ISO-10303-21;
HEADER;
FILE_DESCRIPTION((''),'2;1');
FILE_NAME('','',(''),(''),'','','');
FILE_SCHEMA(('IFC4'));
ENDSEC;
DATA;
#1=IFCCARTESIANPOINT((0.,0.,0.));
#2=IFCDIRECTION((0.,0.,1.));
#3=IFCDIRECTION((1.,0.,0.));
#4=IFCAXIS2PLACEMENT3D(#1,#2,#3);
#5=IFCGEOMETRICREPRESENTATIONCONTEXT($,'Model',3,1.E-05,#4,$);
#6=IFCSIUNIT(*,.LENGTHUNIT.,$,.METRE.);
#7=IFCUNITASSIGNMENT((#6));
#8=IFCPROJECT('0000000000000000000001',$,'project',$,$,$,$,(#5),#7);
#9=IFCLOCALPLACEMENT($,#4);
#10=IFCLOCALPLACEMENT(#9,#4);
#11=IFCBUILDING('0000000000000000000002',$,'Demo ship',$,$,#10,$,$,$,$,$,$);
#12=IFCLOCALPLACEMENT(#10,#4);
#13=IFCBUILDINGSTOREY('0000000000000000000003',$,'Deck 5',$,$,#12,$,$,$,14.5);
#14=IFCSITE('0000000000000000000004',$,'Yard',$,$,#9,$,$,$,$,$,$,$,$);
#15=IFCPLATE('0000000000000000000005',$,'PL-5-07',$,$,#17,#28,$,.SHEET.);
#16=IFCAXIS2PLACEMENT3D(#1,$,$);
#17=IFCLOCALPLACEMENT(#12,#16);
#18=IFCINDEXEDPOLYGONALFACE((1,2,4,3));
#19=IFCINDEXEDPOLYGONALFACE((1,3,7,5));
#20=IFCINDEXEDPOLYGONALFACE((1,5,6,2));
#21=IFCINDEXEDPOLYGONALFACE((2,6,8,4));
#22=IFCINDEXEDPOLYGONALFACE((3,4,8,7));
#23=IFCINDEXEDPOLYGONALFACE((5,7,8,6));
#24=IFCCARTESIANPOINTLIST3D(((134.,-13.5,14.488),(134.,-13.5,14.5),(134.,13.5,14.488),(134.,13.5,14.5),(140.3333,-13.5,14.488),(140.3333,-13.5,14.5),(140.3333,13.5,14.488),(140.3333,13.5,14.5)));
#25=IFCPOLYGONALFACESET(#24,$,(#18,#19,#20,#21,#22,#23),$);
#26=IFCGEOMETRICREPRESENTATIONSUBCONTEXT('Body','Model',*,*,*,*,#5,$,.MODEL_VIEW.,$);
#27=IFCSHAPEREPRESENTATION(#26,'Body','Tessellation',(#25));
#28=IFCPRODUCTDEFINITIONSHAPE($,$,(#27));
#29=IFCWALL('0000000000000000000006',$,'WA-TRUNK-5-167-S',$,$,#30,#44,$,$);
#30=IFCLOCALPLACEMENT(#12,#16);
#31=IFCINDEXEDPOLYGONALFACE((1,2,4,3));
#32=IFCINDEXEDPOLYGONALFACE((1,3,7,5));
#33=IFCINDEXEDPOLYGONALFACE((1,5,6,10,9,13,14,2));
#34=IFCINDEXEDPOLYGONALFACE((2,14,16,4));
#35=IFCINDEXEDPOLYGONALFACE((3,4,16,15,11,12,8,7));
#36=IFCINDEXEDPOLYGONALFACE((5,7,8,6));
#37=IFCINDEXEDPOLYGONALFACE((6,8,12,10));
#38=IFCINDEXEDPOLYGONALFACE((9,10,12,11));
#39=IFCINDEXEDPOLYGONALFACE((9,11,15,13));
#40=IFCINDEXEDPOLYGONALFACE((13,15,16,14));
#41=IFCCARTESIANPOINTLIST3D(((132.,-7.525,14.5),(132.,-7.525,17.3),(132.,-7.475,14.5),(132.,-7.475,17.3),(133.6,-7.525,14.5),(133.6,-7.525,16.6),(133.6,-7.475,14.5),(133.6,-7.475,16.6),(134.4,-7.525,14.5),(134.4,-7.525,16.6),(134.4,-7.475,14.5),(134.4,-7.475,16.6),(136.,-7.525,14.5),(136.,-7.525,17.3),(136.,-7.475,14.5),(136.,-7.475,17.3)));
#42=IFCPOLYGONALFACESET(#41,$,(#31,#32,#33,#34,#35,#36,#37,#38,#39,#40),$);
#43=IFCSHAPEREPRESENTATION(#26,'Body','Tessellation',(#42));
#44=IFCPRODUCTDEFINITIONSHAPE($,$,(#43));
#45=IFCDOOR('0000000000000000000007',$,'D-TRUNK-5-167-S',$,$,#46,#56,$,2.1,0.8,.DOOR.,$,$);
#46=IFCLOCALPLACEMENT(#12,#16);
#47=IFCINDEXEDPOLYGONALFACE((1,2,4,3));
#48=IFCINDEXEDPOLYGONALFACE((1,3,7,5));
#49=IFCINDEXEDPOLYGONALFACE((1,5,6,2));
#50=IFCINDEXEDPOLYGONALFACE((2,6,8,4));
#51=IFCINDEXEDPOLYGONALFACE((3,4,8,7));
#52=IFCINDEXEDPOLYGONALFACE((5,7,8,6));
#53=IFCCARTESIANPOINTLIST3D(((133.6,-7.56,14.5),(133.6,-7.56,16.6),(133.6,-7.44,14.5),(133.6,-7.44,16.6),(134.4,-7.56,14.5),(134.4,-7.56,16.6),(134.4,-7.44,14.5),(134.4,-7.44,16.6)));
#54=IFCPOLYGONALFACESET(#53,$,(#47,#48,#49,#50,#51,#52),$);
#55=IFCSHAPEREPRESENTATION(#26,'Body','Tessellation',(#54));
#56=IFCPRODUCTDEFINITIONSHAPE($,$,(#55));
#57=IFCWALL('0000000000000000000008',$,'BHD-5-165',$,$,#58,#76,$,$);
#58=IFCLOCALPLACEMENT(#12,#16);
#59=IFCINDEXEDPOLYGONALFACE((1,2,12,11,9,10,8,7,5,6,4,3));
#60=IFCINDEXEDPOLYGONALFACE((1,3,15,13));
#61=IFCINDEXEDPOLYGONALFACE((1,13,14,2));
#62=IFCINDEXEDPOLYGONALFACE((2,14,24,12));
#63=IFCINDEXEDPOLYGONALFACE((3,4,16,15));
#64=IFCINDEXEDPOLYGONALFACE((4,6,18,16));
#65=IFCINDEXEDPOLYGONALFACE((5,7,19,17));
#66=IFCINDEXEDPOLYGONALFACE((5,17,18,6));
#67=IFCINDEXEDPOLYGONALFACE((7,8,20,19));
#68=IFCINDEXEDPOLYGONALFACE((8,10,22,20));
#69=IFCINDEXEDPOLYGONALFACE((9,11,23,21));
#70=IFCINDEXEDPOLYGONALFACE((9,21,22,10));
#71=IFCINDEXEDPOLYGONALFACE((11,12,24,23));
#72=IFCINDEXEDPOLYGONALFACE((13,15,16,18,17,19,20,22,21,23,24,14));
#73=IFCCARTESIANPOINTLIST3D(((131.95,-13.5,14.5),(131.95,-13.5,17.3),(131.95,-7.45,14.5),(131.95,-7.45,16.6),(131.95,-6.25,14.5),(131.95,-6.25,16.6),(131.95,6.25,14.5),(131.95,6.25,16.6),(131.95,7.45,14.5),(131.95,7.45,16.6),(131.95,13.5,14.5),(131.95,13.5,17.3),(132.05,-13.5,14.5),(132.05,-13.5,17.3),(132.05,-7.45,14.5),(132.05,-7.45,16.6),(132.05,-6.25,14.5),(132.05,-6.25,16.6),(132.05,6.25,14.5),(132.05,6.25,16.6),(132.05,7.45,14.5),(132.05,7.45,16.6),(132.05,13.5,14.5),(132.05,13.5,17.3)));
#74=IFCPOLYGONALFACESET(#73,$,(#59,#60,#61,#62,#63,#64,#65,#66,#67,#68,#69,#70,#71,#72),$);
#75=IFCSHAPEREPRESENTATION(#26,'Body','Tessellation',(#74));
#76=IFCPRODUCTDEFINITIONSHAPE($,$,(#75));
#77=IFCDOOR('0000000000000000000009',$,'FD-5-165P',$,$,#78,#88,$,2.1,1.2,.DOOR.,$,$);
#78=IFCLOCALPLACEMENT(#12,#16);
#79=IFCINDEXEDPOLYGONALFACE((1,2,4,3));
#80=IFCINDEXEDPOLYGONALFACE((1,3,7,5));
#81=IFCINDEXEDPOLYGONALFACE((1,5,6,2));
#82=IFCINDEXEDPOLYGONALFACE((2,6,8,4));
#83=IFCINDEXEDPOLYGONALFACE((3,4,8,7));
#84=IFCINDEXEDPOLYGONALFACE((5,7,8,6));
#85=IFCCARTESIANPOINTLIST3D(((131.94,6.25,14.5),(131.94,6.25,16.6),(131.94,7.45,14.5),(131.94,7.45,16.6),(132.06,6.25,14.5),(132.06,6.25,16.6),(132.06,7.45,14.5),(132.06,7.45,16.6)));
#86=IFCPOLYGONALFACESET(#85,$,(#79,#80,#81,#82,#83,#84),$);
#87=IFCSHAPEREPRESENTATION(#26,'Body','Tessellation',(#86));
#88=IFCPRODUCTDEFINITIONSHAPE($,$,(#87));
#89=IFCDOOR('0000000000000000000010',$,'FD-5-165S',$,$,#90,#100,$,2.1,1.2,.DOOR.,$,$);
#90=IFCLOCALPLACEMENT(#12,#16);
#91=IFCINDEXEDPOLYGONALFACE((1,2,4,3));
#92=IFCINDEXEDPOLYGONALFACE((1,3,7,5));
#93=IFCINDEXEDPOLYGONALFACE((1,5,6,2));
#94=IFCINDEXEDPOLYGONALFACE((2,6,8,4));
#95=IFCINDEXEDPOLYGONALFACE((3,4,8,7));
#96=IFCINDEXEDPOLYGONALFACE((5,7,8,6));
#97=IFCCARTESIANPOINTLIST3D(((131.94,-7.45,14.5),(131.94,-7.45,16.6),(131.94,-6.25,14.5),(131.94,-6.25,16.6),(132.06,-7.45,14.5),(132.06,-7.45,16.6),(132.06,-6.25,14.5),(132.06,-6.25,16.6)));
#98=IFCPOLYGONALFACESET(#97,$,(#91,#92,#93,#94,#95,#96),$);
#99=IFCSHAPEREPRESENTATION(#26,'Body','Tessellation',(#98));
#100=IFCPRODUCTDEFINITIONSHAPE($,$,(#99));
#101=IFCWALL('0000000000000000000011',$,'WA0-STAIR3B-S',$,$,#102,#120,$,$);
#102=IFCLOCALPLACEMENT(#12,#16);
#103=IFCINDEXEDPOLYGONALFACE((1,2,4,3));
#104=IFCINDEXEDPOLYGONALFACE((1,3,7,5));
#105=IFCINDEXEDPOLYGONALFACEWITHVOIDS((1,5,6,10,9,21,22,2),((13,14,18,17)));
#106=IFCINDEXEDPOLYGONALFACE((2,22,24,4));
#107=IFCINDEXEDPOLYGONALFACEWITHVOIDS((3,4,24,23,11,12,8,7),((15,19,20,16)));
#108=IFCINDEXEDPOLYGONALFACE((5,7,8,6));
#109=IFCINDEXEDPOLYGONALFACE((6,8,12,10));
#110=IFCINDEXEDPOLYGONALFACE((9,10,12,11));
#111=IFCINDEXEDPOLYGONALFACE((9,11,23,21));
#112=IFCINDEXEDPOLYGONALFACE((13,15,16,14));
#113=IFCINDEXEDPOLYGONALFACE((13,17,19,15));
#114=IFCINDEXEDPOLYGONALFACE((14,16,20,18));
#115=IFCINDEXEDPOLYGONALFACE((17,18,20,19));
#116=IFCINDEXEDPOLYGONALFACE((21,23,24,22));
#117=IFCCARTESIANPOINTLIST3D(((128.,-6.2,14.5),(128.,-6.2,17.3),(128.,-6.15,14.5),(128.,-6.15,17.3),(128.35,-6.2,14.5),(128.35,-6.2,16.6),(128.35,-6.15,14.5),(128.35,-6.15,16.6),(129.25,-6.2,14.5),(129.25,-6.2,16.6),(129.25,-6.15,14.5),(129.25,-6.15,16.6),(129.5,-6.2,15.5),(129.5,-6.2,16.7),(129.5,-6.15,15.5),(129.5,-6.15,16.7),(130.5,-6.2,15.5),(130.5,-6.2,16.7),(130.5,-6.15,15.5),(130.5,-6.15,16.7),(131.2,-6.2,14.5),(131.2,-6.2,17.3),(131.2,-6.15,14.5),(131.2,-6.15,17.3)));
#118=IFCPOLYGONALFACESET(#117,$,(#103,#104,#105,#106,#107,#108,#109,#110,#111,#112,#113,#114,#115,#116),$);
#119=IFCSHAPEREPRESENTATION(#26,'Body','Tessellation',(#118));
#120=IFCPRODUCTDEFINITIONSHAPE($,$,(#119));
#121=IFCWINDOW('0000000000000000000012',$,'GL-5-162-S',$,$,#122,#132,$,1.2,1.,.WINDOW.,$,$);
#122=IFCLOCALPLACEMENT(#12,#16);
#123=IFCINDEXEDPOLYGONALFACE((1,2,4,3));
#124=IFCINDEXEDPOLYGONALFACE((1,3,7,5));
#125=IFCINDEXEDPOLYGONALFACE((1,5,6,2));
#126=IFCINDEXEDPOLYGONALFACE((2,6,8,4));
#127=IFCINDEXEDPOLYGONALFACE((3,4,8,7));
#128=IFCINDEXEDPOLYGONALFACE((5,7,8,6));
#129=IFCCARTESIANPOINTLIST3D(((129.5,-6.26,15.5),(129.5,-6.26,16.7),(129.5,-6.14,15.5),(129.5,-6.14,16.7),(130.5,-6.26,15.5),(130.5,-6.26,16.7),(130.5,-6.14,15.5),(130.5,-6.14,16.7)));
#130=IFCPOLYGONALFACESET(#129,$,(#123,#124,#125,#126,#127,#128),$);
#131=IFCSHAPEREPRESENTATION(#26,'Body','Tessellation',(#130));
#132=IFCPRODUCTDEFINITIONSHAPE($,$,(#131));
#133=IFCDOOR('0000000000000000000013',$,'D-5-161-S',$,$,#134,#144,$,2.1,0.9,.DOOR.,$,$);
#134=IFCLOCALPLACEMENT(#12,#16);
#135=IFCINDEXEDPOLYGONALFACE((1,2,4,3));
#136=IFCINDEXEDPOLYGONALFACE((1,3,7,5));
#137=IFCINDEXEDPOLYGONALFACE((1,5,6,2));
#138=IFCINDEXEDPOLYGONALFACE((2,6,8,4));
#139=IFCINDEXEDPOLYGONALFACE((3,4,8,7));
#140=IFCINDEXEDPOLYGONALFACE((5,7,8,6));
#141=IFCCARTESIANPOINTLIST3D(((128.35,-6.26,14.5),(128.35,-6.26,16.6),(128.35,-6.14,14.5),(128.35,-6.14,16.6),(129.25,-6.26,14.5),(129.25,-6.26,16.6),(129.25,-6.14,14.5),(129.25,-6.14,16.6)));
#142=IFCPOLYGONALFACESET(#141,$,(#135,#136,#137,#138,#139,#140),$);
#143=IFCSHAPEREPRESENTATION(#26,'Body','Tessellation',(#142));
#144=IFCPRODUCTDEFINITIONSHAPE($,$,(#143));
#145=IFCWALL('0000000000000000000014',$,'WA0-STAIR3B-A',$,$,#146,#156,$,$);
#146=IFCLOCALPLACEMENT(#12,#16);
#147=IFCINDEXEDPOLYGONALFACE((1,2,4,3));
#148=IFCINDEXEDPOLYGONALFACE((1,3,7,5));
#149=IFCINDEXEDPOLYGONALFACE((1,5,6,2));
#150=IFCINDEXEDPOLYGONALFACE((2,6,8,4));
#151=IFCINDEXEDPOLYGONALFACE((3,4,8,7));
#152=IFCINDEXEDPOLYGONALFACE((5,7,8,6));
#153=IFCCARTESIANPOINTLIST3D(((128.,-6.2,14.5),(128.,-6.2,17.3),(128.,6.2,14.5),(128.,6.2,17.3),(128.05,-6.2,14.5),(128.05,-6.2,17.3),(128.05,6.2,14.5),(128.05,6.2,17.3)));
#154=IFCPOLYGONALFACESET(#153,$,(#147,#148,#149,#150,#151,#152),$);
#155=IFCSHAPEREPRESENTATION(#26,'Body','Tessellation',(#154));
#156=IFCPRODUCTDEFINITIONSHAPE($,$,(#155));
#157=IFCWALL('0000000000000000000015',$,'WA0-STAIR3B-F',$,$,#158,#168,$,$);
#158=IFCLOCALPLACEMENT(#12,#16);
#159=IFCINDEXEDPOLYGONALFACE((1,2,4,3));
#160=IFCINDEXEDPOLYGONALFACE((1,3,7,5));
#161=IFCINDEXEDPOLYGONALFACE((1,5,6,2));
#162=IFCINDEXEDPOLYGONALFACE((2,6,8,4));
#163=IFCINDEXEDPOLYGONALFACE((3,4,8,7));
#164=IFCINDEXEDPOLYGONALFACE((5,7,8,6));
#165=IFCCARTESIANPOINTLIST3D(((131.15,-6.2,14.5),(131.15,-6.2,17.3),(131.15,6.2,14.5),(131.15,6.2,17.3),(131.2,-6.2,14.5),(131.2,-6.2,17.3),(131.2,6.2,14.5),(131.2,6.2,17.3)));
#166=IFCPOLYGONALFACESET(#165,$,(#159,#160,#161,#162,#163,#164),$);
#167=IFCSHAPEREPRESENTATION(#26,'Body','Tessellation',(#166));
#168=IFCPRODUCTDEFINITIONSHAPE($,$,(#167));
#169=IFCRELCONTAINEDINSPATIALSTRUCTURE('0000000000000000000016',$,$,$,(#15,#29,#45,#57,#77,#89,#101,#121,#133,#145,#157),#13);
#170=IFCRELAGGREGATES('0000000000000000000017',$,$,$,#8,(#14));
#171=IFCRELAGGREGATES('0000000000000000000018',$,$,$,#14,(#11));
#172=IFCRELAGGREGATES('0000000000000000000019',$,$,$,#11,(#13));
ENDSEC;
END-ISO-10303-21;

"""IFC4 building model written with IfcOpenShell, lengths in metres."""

from ifc_helpers import new_model, si_unit, frame, frame_2d, origin, origin_with_axes, place, context, subcontext, project, spatial, rectangle, extrude, element, fill, save


model = new_model("IFC4")

# Units and contexts
model_context = context("Model", 3, precision=1e-05, world=origin_with_axes())
body_context = subcontext(model_context, "Body", "Model", "MODEL_VIEW")
ifc_project = project(units=[si_unit("LENGTHUNIT", "METRE")], contexts=[model_context])

# Site, building, storey
site_placement = place(None, origin_with_axes())
site = spatial("IfcSite", under=ifc_project, at=site_placement, Name="Yard")
building_placement = place(site_placement, origin_with_axes())
building = spatial("IfcBuilding", under=site, at=building_placement, Name="Demo ship")
storey_placement = place(building_placement, origin_with_axes())
storey = spatial("IfcBuildingStorey", under=building, at=storey_placement, Name="Deck 5", Elevation=14.5)

# Plate
plate_placement = place(storey_placement, frame((134.0, -13.5, 14.488), z_axis=(0.0, 0.0, 1.0), x_axis=(1.0, 0.0, 0.0)))
element("IfcPlate", 1, at=plate_placement, inside=storey, Name="PL-5-07", PredefinedType="SHEET", context=body_context, shape_type="SweptSolid", body=[
    extrude(rectangle(XDim=6.3333, YDim=27.0, at=frame_2d((3.1667, 13.5))), origin(), (0.0, 0.0, 1.0), 0.012),
])

# Wall, opening, door
wall_1_placement = place(storey_placement, frame((132.0, -7.525, 14.5), z_axis=(0.0, 0.0, 1.0), x_axis=(1.0, 0.0, 0.0)))
wall_1 = element("IfcWall", 2, at=wall_1_placement, inside=storey, Name="WA-TRUNK-5-167-S", context=body_context, shape_type="SweptSolid", body=[
    extrude(rectangle(XDim=4.0, YDim=0.05, at=frame_2d((2.0, 0.025))), origin(), (0.0, 0.0, 1.0), 2.8),
])
opening_1_placement = place(None, frame((133.6, -7.56, 14.5), z_axis=(0.0, 0.0, 1.0), x_axis=(1.0, 0.0, 0.0)))
opening_1 = element("IfcOpeningElement", 3, at=opening_1_placement, cuts=wall_1, context=body_context, shape_type="SweptSolid", body=[
    extrude(rectangle(XDim=0.8, YDim=0.12, at=frame_2d((0.4, 0.06))), origin(), (0.0, 0.0, 1.0), 2.1),
])
door_1_placement = place(storey_placement, frame((133.6, -7.56, 14.5), z_axis=(0.0, 0.0, 1.0), x_axis=(1.0, 0.0, 0.0)))
door_1 = element("IfcDoor", 4, at=door_1_placement, inside=storey, Name="D-TRUNK-5-167-S", OverallHeight=2.1, OverallWidth=0.8, PredefinedType="DOOR", context=body_context, shape_type="SweptSolid", body=[
    extrude(rectangle(XDim=0.8, YDim=0.12, at=frame_2d((0.4, 0.06))), origin(), (0.0, 0.0, 1.0), 2.1),
])
fill(opening_1, door_1)

# Wall, openings, doors
wall_2_placement = place(storey_placement, frame((131.95, -13.5, 14.5), z_axis=(0.0, 0.0, 1.0), x_axis=(1.0, 0.0, 0.0)))
wall_2 = element("IfcWall", 5, at=wall_2_placement, inside=storey, Name="BHD-5-165", context=body_context, shape_type="SweptSolid", body=[
    extrude(rectangle(XDim=0.1, YDim=27.0, at=frame_2d((0.05, 13.5))), origin(), (0.0, 0.0, 1.0), 2.8),
])
opening_2_placement = place(None, frame((131.94, 6.25, 14.5), z_axis=(0.0, 0.0, 1.0), x_axis=(1.0, 0.0, 0.0)))
opening_2 = element("IfcOpeningElement", 6, at=opening_2_placement, cuts=wall_2, context=body_context, shape_type="SweptSolid", body=[
    extrude(rectangle(XDim=0.12, YDim=1.2, at=frame_2d((0.06, 0.6))), origin(), (0.0, 0.0, 1.0), 2.1),
])
opening_3_placement = place(None, frame((131.94, -7.45, 14.5), z_axis=(0.0, 0.0, 1.0), x_axis=(1.0, 0.0, 0.0)))
opening_3 = element("IfcOpeningElement", 7, at=opening_3_placement, cuts=wall_2, context=body_context, shape_type="SweptSolid", body=[
    extrude(rectangle(XDim=0.12, YDim=1.2, at=frame_2d((0.06, 0.6))), origin(), (0.0, 0.0, 1.0), 2.1),
])
door_2_placement = place(storey_placement, frame((131.94, 6.25, 14.5), z_axis=(0.0, 0.0, 1.0), x_axis=(1.0, 0.0, 0.0)))
door_2 = element("IfcDoor", 8, at=door_2_placement, inside=storey, Name="FD-5-165P", OverallHeight=2.1, OverallWidth=1.2, PredefinedType="DOOR", context=body_context, shape_type="SweptSolid", body=[
    extrude(rectangle(XDim=0.12, YDim=1.2, at=frame_2d((0.06, 0.6))), origin(), (0.0, 0.0, 1.0), 2.1),
])
fill(opening_2, door_2)
door_3_placement = place(storey_placement, frame((131.94, -7.45, 14.5), z_axis=(0.0, 0.0, 1.0), x_axis=(1.0, 0.0, 0.0)))
door_3 = element("IfcDoor", 9, at=door_3_placement, inside=storey, Name="FD-5-165S", OverallHeight=2.1, OverallWidth=1.2, PredefinedType="DOOR", context=body_context, shape_type="SweptSolid", body=[
    extrude(rectangle(XDim=0.12, YDim=1.2, at=frame_2d((0.06, 0.6))), origin(), (0.0, 0.0, 1.0), 2.1),
])
fill(opening_3, door_3)

# Wall, openings, window, door
wall_3_placement = place(storey_placement, frame((128.0, -6.2, 14.5), z_axis=(0.0, 0.0, 1.0), x_axis=(1.0, 0.0, 0.0)))
wall_3 = element("IfcWall", 10, at=wall_3_placement, inside=storey, Name="WA0-STAIR3B-S", context=body_context, shape_type="SweptSolid", body=[
    extrude(rectangle(XDim=3.2, YDim=0.05, at=frame_2d((1.6, 0.025))), origin(), (0.0, 0.0, 1.0), 2.8),
])
opening_4_placement = place(None, frame((129.5, -6.26, 15.5), z_axis=(0.0, 0.0, 1.0), x_axis=(1.0, 0.0, 0.0)))
opening_4 = element("IfcOpeningElement", 11, at=opening_4_placement, cuts=wall_3, context=body_context, shape_type="SweptSolid", body=[
    extrude(rectangle(XDim=1.0, YDim=0.12, at=frame_2d((0.5, 0.06))), origin(), (0.0, 0.0, 1.0), 1.2),
])
opening_5_placement = place(None, frame((128.35, -6.26, 14.5), z_axis=(0.0, 0.0, 1.0), x_axis=(1.0, 0.0, 0.0)))
opening_5 = element("IfcOpeningElement", 12, at=opening_5_placement, cuts=wall_3, context=body_context, shape_type="SweptSolid", body=[
    extrude(rectangle(XDim=0.9, YDim=0.12, at=frame_2d((0.45, 0.06))), origin(), (0.0, 0.0, 1.0), 2.1),
])
window_placement = place(storey_placement, frame((129.5, -6.26, 15.5), z_axis=(0.0, 0.0, 1.0), x_axis=(1.0, 0.0, 0.0)))
window = element("IfcWindow", 13, at=window_placement, inside=storey, Name="GL-5-162-S", OverallHeight=1.2, OverallWidth=1.0, PredefinedType="WINDOW", context=body_context, shape_type="SweptSolid", body=[
    extrude(rectangle(XDim=1.0, YDim=0.12, at=frame_2d((0.5, 0.06))), origin(), (0.0, 0.0, 1.0), 1.2),
])
fill(opening_4, window)
door_4_placement = place(storey_placement, frame((128.35, -6.26, 14.5), z_axis=(0.0, 0.0, 1.0), x_axis=(1.0, 0.0, 0.0)))
door_4 = element("IfcDoor", 14, at=door_4_placement, inside=storey, Name="D-5-161-S", OverallHeight=2.1, OverallWidth=0.9, PredefinedType="DOOR", context=body_context, shape_type="SweptSolid", body=[
    extrude(rectangle(XDim=0.9, YDim=0.12, at=frame_2d((0.45, 0.06))), origin(), (0.0, 0.0, 1.0), 2.1),
])
fill(opening_5, door_4)

# Walls
for number, where, z_axis, x_axis, name in (
    (15, (128.0, -6.2, 14.5), (0.0, 0.0, 1.0), (1.0, 0.0, 0.0), "WA0-STAIR3B-A"),
    (16, (131.15, -6.2, 14.5), (0.0, 0.0, 1.0), (1.0, 0.0, 0.0), "WA0-STAIR3B-F"),
):
    element("IfcWall", number, at=place(storey_placement, frame(where, z_axis=z_axis, x_axis=x_axis)), inside=storey, Name=name, context=body_context, shape_type="SweptSolid", body=[
        extrude(rectangle(XDim=0.05, YDim=12.4, at=frame_2d((0.025, 6.2))), origin(), (0.0, 0.0, 1.0), 2.8),
    ])

save(model, "model.ifc")
